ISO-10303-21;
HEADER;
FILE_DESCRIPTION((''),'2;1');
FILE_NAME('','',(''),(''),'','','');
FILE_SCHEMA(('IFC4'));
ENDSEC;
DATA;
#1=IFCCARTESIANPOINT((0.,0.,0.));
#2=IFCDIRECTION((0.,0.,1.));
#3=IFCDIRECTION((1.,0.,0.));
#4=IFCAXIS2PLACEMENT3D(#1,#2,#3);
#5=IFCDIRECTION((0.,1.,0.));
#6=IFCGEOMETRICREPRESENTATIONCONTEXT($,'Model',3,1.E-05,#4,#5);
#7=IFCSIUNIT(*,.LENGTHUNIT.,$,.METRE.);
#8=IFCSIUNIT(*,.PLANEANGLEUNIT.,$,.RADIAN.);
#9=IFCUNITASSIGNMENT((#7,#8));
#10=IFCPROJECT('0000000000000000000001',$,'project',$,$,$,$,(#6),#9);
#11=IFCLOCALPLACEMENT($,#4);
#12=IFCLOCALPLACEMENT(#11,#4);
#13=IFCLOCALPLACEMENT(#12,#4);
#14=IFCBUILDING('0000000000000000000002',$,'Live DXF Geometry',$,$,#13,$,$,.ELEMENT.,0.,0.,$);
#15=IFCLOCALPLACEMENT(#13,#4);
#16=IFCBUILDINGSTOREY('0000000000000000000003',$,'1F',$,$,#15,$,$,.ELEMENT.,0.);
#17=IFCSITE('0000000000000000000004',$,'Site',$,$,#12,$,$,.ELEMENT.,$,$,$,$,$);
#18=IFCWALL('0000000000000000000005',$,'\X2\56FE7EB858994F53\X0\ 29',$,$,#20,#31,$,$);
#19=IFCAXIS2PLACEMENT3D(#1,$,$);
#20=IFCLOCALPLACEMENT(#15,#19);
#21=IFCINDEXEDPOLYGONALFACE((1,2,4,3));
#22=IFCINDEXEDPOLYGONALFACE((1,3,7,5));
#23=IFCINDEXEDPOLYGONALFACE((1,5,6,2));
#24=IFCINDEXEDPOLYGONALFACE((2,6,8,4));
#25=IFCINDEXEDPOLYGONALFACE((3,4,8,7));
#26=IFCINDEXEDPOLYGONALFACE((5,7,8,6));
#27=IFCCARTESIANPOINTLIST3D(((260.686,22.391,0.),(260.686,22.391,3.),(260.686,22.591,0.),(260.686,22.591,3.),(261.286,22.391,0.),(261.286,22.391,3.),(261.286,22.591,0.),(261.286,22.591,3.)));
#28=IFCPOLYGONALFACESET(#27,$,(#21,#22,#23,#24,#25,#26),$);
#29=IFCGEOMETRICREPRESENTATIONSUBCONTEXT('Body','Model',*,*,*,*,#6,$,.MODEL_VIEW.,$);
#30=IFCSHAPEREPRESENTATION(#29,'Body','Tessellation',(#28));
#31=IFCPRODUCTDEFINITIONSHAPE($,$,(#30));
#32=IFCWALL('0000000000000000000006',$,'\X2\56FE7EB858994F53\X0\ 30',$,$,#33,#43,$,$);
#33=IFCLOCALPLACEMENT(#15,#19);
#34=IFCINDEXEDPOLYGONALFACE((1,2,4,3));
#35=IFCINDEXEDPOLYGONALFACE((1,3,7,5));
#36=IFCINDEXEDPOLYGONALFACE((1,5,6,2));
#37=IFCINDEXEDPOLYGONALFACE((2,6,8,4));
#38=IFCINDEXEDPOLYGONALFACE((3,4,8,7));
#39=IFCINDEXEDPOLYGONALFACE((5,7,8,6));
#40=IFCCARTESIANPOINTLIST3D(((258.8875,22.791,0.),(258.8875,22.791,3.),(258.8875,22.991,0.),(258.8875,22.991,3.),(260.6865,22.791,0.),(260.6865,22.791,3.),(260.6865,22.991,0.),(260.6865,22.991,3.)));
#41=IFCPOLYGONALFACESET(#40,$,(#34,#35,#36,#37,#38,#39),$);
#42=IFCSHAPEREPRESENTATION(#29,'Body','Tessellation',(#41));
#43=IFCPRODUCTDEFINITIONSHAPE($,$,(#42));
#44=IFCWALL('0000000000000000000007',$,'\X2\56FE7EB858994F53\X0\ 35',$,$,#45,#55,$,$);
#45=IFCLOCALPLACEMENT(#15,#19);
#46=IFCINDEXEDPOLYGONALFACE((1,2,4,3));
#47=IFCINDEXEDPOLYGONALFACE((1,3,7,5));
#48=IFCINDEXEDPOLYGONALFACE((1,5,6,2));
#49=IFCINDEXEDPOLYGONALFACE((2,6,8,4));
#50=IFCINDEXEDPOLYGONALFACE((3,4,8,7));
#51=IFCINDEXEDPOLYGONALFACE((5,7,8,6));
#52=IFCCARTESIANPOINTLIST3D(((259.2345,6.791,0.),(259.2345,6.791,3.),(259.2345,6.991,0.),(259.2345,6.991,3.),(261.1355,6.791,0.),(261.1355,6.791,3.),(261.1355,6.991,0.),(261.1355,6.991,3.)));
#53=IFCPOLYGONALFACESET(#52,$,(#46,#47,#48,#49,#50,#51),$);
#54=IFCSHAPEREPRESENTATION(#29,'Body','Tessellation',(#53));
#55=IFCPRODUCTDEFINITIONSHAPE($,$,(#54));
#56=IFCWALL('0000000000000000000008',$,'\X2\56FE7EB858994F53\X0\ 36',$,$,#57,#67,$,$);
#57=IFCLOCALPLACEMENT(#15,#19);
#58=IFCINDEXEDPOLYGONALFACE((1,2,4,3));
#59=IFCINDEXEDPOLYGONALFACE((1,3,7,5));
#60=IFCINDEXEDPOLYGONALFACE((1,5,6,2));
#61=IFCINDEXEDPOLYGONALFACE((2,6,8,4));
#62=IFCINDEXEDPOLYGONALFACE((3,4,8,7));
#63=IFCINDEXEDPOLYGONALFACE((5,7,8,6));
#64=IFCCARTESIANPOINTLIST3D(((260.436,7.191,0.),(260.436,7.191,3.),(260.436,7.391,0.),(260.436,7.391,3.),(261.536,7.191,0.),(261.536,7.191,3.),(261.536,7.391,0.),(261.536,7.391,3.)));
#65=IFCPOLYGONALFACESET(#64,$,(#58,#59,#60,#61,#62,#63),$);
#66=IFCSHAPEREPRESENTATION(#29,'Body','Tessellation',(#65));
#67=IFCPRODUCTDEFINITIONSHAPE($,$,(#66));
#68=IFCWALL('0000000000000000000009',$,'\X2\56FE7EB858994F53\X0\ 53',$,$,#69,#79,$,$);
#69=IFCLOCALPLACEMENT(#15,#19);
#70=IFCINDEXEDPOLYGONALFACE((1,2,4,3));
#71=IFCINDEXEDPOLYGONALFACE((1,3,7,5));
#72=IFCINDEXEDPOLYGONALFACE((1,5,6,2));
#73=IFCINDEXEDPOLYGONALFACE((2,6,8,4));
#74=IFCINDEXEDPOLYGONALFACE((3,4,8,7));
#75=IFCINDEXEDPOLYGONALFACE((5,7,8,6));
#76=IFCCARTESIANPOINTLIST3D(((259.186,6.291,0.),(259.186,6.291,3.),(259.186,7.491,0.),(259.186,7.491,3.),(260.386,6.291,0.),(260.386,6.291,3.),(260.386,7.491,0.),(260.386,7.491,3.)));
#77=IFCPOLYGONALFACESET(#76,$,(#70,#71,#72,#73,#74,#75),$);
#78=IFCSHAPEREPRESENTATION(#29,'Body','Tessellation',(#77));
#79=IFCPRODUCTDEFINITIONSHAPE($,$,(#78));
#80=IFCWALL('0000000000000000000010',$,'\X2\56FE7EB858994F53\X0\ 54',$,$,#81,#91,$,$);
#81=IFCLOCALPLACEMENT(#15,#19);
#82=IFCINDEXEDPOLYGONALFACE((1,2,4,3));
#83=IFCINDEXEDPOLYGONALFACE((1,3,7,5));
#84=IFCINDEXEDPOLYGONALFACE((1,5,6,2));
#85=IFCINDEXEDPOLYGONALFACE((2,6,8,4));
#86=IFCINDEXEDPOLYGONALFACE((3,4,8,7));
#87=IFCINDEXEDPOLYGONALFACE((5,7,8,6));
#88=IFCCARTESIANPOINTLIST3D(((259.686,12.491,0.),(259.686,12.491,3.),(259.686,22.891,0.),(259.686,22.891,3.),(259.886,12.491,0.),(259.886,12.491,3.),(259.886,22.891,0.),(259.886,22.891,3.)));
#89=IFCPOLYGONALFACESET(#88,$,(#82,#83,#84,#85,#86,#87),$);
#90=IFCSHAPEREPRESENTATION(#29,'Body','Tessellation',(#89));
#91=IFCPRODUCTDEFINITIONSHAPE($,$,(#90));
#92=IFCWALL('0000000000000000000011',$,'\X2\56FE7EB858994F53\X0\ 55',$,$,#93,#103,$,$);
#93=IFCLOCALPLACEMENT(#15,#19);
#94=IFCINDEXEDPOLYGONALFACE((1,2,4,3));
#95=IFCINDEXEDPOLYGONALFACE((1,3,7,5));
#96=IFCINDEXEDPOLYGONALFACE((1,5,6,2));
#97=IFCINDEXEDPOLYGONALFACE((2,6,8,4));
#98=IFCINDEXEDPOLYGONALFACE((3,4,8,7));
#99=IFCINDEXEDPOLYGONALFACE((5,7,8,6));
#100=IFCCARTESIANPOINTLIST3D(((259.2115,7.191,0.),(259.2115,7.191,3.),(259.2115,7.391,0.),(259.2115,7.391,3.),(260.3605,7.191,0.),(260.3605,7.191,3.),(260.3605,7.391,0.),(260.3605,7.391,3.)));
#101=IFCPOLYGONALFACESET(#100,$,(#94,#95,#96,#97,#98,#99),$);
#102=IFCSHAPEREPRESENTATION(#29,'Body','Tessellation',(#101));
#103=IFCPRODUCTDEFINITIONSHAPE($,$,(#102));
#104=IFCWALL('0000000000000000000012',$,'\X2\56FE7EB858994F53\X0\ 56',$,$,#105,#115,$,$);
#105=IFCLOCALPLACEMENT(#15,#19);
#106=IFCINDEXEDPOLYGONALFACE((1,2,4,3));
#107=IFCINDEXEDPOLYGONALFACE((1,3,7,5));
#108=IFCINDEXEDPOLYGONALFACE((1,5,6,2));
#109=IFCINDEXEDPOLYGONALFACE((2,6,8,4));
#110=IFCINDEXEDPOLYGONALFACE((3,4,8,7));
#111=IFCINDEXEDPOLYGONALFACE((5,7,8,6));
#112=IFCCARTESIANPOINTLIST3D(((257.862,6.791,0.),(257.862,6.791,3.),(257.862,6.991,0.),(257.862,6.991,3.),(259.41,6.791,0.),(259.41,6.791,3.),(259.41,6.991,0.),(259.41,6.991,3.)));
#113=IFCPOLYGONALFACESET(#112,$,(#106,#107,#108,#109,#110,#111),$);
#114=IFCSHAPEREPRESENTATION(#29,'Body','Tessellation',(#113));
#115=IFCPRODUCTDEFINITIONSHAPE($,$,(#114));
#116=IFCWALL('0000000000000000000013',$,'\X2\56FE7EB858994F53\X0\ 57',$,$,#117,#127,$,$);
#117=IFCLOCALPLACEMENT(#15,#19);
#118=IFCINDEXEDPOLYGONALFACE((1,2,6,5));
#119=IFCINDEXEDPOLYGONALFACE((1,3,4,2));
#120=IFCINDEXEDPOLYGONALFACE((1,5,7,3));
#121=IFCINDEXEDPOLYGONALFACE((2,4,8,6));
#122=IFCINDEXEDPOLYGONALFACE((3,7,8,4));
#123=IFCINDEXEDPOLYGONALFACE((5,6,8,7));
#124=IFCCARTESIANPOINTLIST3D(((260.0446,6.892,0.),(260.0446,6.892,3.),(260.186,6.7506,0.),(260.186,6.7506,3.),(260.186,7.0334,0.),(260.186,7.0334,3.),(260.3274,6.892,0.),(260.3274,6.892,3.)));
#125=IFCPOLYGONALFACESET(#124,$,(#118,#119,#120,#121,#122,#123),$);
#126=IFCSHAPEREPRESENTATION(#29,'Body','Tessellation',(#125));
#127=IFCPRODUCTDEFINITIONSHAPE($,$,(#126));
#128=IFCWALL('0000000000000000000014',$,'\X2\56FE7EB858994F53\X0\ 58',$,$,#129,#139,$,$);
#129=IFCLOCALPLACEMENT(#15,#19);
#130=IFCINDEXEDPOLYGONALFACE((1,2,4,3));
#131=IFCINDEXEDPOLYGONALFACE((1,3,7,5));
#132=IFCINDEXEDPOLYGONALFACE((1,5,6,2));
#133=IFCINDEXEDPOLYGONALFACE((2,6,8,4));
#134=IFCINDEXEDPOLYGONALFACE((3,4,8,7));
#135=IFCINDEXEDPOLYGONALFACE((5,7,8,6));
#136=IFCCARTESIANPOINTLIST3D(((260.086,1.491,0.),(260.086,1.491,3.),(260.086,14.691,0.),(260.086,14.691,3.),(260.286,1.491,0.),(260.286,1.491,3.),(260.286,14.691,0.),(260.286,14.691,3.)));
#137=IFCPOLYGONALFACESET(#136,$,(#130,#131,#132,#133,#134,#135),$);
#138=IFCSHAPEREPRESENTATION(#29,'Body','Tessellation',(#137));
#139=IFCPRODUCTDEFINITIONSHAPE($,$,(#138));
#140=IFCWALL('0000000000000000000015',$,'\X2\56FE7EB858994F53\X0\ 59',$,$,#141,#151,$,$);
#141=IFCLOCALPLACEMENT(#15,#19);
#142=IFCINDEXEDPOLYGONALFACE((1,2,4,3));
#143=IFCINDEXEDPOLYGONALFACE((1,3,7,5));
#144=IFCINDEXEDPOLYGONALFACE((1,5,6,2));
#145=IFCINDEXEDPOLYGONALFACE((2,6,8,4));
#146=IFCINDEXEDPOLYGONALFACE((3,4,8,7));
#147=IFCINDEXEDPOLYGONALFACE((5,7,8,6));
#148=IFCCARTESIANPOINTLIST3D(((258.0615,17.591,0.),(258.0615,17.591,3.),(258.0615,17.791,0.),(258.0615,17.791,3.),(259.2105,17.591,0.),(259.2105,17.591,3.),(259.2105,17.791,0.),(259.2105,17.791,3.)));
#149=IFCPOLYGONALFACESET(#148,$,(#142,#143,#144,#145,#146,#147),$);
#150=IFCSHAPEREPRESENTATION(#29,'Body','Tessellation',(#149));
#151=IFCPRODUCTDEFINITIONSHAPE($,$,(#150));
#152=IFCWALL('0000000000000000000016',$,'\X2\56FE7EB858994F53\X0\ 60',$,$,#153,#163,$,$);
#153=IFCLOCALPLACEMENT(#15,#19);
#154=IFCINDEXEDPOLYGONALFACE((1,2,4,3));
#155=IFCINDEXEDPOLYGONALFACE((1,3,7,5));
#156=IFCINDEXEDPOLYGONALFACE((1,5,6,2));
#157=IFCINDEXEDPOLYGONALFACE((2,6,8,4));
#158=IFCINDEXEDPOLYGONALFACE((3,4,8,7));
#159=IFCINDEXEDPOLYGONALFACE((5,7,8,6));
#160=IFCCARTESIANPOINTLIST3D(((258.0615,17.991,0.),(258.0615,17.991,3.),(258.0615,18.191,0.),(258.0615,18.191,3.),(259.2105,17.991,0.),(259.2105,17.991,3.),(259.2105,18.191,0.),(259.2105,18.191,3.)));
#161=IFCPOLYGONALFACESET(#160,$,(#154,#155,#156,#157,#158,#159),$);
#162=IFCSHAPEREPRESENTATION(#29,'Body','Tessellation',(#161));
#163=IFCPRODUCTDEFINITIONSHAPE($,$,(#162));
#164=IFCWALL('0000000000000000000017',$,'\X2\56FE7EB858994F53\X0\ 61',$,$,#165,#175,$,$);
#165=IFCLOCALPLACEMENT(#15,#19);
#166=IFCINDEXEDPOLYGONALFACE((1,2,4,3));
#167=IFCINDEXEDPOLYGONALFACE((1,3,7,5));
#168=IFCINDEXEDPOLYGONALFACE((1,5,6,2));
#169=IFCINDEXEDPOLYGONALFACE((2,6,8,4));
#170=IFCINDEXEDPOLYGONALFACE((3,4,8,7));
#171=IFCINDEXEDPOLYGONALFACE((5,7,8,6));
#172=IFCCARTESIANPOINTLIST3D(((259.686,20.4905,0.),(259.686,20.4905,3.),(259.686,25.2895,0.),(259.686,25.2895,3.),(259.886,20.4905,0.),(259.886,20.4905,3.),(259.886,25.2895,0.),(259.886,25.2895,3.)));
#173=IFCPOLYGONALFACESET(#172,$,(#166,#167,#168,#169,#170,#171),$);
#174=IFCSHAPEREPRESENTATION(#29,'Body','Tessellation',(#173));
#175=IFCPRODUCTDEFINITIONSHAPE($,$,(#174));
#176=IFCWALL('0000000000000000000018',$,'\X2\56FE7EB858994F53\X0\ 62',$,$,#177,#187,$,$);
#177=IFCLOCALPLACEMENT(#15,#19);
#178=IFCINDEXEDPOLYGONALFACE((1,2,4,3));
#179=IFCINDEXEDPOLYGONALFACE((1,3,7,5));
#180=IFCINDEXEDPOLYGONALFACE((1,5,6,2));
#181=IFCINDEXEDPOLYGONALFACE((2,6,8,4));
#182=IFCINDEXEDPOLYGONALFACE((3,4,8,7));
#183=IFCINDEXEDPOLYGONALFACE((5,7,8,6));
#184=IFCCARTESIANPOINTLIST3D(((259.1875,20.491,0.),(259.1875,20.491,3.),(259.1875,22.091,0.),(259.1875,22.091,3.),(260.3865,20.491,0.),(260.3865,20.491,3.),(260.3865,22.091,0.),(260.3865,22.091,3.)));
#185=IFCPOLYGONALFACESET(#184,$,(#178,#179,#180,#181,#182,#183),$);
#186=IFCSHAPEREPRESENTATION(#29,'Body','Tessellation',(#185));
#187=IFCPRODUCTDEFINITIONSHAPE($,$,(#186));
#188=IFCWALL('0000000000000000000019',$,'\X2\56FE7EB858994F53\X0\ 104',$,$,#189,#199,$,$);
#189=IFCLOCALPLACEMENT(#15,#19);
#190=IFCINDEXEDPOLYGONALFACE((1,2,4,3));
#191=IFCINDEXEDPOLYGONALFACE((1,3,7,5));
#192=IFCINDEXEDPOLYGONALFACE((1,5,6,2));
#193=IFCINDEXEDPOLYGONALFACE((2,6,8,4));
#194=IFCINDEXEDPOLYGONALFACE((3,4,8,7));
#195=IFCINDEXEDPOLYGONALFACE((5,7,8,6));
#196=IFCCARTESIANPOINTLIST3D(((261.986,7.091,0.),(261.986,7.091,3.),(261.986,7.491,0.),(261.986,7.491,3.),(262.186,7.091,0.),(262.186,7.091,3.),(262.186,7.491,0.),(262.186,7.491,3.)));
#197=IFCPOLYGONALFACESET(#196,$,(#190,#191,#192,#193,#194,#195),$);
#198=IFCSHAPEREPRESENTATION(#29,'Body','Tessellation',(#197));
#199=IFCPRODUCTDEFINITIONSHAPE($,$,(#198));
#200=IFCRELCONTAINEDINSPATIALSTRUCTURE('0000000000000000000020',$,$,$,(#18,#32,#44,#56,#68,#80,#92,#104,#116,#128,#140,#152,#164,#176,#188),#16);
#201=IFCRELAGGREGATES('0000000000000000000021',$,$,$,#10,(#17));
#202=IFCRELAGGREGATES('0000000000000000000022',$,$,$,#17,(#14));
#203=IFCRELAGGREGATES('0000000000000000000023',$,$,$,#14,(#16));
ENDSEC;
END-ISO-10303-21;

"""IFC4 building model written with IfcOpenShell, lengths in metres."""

from ifc_helpers import new_model, si_unit, direction, frame, frame_2d, origin_with_axes, place, context, subcontext, project, spatial, rectangle, extrude, element, save


model = new_model("IFC4")

# Units and contexts
model_context = context("Model", 3, precision=1e-05, world=origin_with_axes(), true_north=direction((0.0, 1.0, 0.0)))
body_context = subcontext(model_context, "Body", "Model", "MODEL_VIEW")
ifc_project = project(units=[si_unit("LENGTHUNIT", "METRE"), si_unit("PLANEANGLEUNIT", "RADIAN")], contexts=[model_context])

# Site, building, storey
placement = place(None, origin_with_axes())
site_placement = place(placement, origin_with_axes())
site = spatial("IfcSite", under=ifc_project, at=site_placement, Name="Site", CompositionType="ELEMENT")
building_placement = place(site_placement, origin_with_axes())
building = spatial("IfcBuilding", under=site, at=building_placement, Name="Live DXF Geometry", CompositionType="ELEMENT", ElevationOfRefHeight=0.0, ElevationOfTerrain=0.0)
storey_placement = place(building_placement, origin_with_axes())
storey = spatial("IfcBuildingStorey", under=building, at=storey_placement, Name="1F", CompositionType="ELEMENT", Elevation=0.0)

# Walls
wall_1_placement = place(storey_placement, frame((260.986, 22.491, 0.0), z_axis=(0.0, 0.0, 1.0), x_axis=(1.0, 0.0, 0.0)))
element("IfcWall", 1, at=wall_1_placement, inside=storey, Name="图纸墙体 29", context=body_context, shape_type="SweptSolid", body=[
    extrude(rectangle(XDim=0.6, YDim=0.2, at=frame_2d((0.0, 0.0), x_axis=(1.0, 0.0, 0.0))), frame((0.0, 0.0, 0.0), z_axis=(0.0, 0.0, 1.0)), (0.0, 0.0, 1.0), 3.0),
])
wall_2_placement = place(storey_placement, frame((259.787, 22.891, 0.0), z_axis=(0.0, 0.0, 1.0), x_axis=(1.0, 0.0, 0.0)))
element("IfcWall", 2, at=wall_2_placement, inside=storey, Name="图纸墙体 30", context=body_context, shape_type="SweptSolid", body=[
    extrude(rectangle(XDim=1.799, YDim=0.2, at=frame_2d((0.0, 0.0), x_axis=(1.0, 0.0, 0.0))), frame((0.0, 0.0, 0.0), z_axis=(0.0, 0.0, 1.0)), (0.0, 0.0, 1.0), 3.0),
])
wall_3_placement = place(storey_placement, frame((260.185, 6.891, 0.0), z_axis=(0.0, 0.0, 1.0), x_axis=(1.0, 0.0, 0.0)))
element("IfcWall", 3, at=wall_3_placement, inside=storey, Name="图纸墙体 35", context=body_context, shape_type="SweptSolid", body=[
    extrude(rectangle(XDim=1.901, YDim=0.2, at=frame_2d((0.0, 0.0), x_axis=(1.0, 0.0, 0.0))), frame((0.0, 0.0, 0.0), z_axis=(0.0, 0.0, 1.0)), (0.0, 0.0, 1.0), 3.0),
])
wall_4_placement = place(storey_placement, frame((260.986, 7.291, 0.0), z_axis=(0.0, 0.0, 1.0), x_axis=(1.0, 0.0, 0.0)))
element("IfcWall", 4, at=wall_4_placement, inside=storey, Name="图纸墙体 36", context=body_context, shape_type="SweptSolid", body=[
    extrude(rectangle(XDim=1.1, YDim=0.2, at=frame_2d((0.0, 0.0), x_axis=(1.0, 0.0, 0.0))), frame((0.0, 0.0, 0.0), z_axis=(0.0, 0.0, 1.0)), (0.0, 0.0, 1.0), 3.0),
])
wall_5_placement = place(storey_placement, frame((259.786, 6.891, 0.0), z_axis=(0.0, 0.0, 1.0), x_axis=(1.0, 0.0, 0.0)))
element("IfcWall", 5, at=wall_5_placement, inside=storey, Name="图纸墙体 53", context=body_context, shape_type="SweptSolid", body=[
    extrude(rectangle(XDim=1.2, YDim=1.2, at=frame_2d((0.0, 0.0), x_axis=(1.0, 0.0, 0.0))), frame((0.0, 0.0, 0.0), z_axis=(0.0, 0.0, 1.0)), (0.0, 0.0, 1.0), 3.0),
])
wall_6_placement = place(storey_placement, frame((259.786, 17.691, 0.0), z_axis=(0.0, 0.0, 1.0), x_axis=(0.0, -1.0, 0.0)))
element("IfcWall", 6, at=wall_6_placement, inside=storey, Name="图纸墙体 54", context=body_context, shape_type="SweptSolid", body=[
    extrude(rectangle(XDim=10.4, YDim=0.2, at=frame_2d((0.0, 0.0), x_axis=(1.0, 0.0, 0.0))), frame((0.0, 0.0, 0.0), z_axis=(0.0, 0.0, 1.0)), (0.0, 0.0, 1.0), 3.0),
])
wall_7_placement = place(storey_placement, frame((259.786, 7.291, 0.0), z_axis=(0.0, 0.0, 1.0), x_axis=(-1.0, 0.0, 0.0)))
element("IfcWall", 7, at=wall_7_placement, inside=storey, Name="图纸墙体 55", context=body_context, shape_type="SweptSolid", body=[
    extrude(rectangle(XDim=1.149, YDim=0.2, at=frame_2d((0.0, 0.0), x_axis=(1.0, 0.0, 0.0))), frame((0.0, 0.0, 0.0), z_axis=(0.0, 0.0, 1.0)), (0.0, 0.0, 1.0), 3.0),
])
wall_8_placement = place(storey_placement, frame((258.636, 6.891, 0.0), z_axis=(0.0, 0.0, 1.0), x_axis=(1.0, 0.0, 0.0)))
element("IfcWall", 8, at=wall_8_placement, inside=storey, Name="图纸墙体 56", context=body_context, shape_type="SweptSolid", body=[
    extrude(rectangle(XDim=1.548, YDim=0.2, at=frame_2d((0.0, 0.0), x_axis=(1.0, 0.0, 0.0))), frame((0.0, 0.0, 0.0), z_axis=(0.0, 0.0, 1.0)), (0.0, 0.0, 1.0), 3.0),
])
wall_9_placement = place(storey_placement, frame((260.186, 6.892, 0.0), z_axis=(0.0, 0.0, 1.0), x_axis=(-0.707107, -0.707107, 0.0)))
element("IfcWall", 9, at=wall_9_placement, inside=storey, Name="图纸墙体 57", context=body_context, shape_type="SweptSolid", body=[
    extrude(rectangle(XDim=0.2, YDim=0.2, at=frame_2d((0.0, 0.0), x_axis=(1.0, 0.0, 0.0))), frame((0.0, 0.0, 0.0), z_axis=(0.0, 0.0, 1.0)), (0.0, 0.0, 1.0), 3.0),
])
wall_10_placement = place(storey_placement, frame((260.186, 8.091, 0.0), z_axis=(0.0, 0.0, 1.0), x_axis=(0.0, 1.0, 0.0)))
element("IfcWall", 10, at=wall_10_placement, inside=storey, Name="图纸墙体 58", context=body_context, shape_type="SweptSolid", body=[
    extrude(rectangle(XDim=13.2, YDim=0.2, at=frame_2d((0.0, 0.0), x_axis=(1.0, 0.0, 0.0))), frame((0.0, 0.0, 0.0), z_axis=(0.0, 0.0, 1.0)), (0.0, 0.0, 1.0), 3.0),
])
for number, where, z_axis, x_axis, name in (
    (11, (258.636, 17.691, 0.0), (0.0, 0.0, 1.0), (1.0, 0.0, 0.0), "图纸墙体 59"),
    (12, (258.636, 18.091, 0.0), (0.0, 0.0, 1.0), (1.0, 0.0, 0.0), "图纸墙体 60"),
):
    element("IfcWall", number, at=place(storey_placement, frame(where, z_axis=z_axis, x_axis=x_axis)), inside=storey, Name=name, context=body_context, shape_type="SweptSolid", body=[
        extrude(rectangle(XDim=1.149, YDim=0.2, at=frame_2d((0.0, 0.0), x_axis=(1.0, 0.0, 0.0))), frame((0.0, 0.0, 0.0), z_axis=(0.0, 0.0, 1.0)), (0.0, 0.0, 1.0), 3.0),
    ])
wall_11_placement = place(storey_placement, frame((259.786, 22.89, 0.0), z_axis=(0.0, 0.0, 1.0), x_axis=(0.0, -1.0, 0.0)))
element("IfcWall", 13, at=wall_11_placement, inside=storey, Name="图纸墙体 61", context=body_context, shape_type="SweptSolid", body=[
    extrude(rectangle(XDim=4.799, YDim=0.2, at=frame_2d((0.0, 0.0), x_axis=(1.0, 0.0, 0.0))), frame((0.0, 0.0, 0.0), z_axis=(0.0, 0.0, 1.0)), (0.0, 0.0, 1.0), 3.0),
])
wall_12_placement = place(storey_placement, frame((259.787, 21.291, 0.0), z_axis=(0.0, 0.0, 1.0), x_axis=(1.0, 0.0, 0.0)))
element("IfcWall", 14, at=wall_12_placement, inside=storey, Name="图纸墙体 62", context=body_context, shape_type="SweptSolid", body=[
    extrude(rectangle(XDim=1.199, YDim=1.6, at=frame_2d((0.0, 0.0), x_axis=(1.0, 0.0, 0.0))), frame((0.0, 0.0, 0.0), z_axis=(0.0, 0.0, 1.0)), (0.0, 0.0, 1.0), 3.0),
])
wall_13_placement = place(storey_placement, frame((262.086, 7.291, 0.0), z_axis=(0.0, 0.0, 1.0), x_axis=(0.0, -1.0, 0.0)))
element("IfcWall", 15, at=wall_13_placement, inside=storey, Name="图纸墙体 104", context=body_context, shape_type="SweptSolid", body=[
    extrude(rectangle(XDim=0.4, YDim=0.2, at=frame_2d((0.0, 0.0), x_axis=(1.0, 0.0, 0.0))), frame((0.0, 0.0, 0.0), z_axis=(0.0, 0.0, 1.0)), (0.0, 0.0, 1.0), 3.0),
])

save(model, "model.ifc")
